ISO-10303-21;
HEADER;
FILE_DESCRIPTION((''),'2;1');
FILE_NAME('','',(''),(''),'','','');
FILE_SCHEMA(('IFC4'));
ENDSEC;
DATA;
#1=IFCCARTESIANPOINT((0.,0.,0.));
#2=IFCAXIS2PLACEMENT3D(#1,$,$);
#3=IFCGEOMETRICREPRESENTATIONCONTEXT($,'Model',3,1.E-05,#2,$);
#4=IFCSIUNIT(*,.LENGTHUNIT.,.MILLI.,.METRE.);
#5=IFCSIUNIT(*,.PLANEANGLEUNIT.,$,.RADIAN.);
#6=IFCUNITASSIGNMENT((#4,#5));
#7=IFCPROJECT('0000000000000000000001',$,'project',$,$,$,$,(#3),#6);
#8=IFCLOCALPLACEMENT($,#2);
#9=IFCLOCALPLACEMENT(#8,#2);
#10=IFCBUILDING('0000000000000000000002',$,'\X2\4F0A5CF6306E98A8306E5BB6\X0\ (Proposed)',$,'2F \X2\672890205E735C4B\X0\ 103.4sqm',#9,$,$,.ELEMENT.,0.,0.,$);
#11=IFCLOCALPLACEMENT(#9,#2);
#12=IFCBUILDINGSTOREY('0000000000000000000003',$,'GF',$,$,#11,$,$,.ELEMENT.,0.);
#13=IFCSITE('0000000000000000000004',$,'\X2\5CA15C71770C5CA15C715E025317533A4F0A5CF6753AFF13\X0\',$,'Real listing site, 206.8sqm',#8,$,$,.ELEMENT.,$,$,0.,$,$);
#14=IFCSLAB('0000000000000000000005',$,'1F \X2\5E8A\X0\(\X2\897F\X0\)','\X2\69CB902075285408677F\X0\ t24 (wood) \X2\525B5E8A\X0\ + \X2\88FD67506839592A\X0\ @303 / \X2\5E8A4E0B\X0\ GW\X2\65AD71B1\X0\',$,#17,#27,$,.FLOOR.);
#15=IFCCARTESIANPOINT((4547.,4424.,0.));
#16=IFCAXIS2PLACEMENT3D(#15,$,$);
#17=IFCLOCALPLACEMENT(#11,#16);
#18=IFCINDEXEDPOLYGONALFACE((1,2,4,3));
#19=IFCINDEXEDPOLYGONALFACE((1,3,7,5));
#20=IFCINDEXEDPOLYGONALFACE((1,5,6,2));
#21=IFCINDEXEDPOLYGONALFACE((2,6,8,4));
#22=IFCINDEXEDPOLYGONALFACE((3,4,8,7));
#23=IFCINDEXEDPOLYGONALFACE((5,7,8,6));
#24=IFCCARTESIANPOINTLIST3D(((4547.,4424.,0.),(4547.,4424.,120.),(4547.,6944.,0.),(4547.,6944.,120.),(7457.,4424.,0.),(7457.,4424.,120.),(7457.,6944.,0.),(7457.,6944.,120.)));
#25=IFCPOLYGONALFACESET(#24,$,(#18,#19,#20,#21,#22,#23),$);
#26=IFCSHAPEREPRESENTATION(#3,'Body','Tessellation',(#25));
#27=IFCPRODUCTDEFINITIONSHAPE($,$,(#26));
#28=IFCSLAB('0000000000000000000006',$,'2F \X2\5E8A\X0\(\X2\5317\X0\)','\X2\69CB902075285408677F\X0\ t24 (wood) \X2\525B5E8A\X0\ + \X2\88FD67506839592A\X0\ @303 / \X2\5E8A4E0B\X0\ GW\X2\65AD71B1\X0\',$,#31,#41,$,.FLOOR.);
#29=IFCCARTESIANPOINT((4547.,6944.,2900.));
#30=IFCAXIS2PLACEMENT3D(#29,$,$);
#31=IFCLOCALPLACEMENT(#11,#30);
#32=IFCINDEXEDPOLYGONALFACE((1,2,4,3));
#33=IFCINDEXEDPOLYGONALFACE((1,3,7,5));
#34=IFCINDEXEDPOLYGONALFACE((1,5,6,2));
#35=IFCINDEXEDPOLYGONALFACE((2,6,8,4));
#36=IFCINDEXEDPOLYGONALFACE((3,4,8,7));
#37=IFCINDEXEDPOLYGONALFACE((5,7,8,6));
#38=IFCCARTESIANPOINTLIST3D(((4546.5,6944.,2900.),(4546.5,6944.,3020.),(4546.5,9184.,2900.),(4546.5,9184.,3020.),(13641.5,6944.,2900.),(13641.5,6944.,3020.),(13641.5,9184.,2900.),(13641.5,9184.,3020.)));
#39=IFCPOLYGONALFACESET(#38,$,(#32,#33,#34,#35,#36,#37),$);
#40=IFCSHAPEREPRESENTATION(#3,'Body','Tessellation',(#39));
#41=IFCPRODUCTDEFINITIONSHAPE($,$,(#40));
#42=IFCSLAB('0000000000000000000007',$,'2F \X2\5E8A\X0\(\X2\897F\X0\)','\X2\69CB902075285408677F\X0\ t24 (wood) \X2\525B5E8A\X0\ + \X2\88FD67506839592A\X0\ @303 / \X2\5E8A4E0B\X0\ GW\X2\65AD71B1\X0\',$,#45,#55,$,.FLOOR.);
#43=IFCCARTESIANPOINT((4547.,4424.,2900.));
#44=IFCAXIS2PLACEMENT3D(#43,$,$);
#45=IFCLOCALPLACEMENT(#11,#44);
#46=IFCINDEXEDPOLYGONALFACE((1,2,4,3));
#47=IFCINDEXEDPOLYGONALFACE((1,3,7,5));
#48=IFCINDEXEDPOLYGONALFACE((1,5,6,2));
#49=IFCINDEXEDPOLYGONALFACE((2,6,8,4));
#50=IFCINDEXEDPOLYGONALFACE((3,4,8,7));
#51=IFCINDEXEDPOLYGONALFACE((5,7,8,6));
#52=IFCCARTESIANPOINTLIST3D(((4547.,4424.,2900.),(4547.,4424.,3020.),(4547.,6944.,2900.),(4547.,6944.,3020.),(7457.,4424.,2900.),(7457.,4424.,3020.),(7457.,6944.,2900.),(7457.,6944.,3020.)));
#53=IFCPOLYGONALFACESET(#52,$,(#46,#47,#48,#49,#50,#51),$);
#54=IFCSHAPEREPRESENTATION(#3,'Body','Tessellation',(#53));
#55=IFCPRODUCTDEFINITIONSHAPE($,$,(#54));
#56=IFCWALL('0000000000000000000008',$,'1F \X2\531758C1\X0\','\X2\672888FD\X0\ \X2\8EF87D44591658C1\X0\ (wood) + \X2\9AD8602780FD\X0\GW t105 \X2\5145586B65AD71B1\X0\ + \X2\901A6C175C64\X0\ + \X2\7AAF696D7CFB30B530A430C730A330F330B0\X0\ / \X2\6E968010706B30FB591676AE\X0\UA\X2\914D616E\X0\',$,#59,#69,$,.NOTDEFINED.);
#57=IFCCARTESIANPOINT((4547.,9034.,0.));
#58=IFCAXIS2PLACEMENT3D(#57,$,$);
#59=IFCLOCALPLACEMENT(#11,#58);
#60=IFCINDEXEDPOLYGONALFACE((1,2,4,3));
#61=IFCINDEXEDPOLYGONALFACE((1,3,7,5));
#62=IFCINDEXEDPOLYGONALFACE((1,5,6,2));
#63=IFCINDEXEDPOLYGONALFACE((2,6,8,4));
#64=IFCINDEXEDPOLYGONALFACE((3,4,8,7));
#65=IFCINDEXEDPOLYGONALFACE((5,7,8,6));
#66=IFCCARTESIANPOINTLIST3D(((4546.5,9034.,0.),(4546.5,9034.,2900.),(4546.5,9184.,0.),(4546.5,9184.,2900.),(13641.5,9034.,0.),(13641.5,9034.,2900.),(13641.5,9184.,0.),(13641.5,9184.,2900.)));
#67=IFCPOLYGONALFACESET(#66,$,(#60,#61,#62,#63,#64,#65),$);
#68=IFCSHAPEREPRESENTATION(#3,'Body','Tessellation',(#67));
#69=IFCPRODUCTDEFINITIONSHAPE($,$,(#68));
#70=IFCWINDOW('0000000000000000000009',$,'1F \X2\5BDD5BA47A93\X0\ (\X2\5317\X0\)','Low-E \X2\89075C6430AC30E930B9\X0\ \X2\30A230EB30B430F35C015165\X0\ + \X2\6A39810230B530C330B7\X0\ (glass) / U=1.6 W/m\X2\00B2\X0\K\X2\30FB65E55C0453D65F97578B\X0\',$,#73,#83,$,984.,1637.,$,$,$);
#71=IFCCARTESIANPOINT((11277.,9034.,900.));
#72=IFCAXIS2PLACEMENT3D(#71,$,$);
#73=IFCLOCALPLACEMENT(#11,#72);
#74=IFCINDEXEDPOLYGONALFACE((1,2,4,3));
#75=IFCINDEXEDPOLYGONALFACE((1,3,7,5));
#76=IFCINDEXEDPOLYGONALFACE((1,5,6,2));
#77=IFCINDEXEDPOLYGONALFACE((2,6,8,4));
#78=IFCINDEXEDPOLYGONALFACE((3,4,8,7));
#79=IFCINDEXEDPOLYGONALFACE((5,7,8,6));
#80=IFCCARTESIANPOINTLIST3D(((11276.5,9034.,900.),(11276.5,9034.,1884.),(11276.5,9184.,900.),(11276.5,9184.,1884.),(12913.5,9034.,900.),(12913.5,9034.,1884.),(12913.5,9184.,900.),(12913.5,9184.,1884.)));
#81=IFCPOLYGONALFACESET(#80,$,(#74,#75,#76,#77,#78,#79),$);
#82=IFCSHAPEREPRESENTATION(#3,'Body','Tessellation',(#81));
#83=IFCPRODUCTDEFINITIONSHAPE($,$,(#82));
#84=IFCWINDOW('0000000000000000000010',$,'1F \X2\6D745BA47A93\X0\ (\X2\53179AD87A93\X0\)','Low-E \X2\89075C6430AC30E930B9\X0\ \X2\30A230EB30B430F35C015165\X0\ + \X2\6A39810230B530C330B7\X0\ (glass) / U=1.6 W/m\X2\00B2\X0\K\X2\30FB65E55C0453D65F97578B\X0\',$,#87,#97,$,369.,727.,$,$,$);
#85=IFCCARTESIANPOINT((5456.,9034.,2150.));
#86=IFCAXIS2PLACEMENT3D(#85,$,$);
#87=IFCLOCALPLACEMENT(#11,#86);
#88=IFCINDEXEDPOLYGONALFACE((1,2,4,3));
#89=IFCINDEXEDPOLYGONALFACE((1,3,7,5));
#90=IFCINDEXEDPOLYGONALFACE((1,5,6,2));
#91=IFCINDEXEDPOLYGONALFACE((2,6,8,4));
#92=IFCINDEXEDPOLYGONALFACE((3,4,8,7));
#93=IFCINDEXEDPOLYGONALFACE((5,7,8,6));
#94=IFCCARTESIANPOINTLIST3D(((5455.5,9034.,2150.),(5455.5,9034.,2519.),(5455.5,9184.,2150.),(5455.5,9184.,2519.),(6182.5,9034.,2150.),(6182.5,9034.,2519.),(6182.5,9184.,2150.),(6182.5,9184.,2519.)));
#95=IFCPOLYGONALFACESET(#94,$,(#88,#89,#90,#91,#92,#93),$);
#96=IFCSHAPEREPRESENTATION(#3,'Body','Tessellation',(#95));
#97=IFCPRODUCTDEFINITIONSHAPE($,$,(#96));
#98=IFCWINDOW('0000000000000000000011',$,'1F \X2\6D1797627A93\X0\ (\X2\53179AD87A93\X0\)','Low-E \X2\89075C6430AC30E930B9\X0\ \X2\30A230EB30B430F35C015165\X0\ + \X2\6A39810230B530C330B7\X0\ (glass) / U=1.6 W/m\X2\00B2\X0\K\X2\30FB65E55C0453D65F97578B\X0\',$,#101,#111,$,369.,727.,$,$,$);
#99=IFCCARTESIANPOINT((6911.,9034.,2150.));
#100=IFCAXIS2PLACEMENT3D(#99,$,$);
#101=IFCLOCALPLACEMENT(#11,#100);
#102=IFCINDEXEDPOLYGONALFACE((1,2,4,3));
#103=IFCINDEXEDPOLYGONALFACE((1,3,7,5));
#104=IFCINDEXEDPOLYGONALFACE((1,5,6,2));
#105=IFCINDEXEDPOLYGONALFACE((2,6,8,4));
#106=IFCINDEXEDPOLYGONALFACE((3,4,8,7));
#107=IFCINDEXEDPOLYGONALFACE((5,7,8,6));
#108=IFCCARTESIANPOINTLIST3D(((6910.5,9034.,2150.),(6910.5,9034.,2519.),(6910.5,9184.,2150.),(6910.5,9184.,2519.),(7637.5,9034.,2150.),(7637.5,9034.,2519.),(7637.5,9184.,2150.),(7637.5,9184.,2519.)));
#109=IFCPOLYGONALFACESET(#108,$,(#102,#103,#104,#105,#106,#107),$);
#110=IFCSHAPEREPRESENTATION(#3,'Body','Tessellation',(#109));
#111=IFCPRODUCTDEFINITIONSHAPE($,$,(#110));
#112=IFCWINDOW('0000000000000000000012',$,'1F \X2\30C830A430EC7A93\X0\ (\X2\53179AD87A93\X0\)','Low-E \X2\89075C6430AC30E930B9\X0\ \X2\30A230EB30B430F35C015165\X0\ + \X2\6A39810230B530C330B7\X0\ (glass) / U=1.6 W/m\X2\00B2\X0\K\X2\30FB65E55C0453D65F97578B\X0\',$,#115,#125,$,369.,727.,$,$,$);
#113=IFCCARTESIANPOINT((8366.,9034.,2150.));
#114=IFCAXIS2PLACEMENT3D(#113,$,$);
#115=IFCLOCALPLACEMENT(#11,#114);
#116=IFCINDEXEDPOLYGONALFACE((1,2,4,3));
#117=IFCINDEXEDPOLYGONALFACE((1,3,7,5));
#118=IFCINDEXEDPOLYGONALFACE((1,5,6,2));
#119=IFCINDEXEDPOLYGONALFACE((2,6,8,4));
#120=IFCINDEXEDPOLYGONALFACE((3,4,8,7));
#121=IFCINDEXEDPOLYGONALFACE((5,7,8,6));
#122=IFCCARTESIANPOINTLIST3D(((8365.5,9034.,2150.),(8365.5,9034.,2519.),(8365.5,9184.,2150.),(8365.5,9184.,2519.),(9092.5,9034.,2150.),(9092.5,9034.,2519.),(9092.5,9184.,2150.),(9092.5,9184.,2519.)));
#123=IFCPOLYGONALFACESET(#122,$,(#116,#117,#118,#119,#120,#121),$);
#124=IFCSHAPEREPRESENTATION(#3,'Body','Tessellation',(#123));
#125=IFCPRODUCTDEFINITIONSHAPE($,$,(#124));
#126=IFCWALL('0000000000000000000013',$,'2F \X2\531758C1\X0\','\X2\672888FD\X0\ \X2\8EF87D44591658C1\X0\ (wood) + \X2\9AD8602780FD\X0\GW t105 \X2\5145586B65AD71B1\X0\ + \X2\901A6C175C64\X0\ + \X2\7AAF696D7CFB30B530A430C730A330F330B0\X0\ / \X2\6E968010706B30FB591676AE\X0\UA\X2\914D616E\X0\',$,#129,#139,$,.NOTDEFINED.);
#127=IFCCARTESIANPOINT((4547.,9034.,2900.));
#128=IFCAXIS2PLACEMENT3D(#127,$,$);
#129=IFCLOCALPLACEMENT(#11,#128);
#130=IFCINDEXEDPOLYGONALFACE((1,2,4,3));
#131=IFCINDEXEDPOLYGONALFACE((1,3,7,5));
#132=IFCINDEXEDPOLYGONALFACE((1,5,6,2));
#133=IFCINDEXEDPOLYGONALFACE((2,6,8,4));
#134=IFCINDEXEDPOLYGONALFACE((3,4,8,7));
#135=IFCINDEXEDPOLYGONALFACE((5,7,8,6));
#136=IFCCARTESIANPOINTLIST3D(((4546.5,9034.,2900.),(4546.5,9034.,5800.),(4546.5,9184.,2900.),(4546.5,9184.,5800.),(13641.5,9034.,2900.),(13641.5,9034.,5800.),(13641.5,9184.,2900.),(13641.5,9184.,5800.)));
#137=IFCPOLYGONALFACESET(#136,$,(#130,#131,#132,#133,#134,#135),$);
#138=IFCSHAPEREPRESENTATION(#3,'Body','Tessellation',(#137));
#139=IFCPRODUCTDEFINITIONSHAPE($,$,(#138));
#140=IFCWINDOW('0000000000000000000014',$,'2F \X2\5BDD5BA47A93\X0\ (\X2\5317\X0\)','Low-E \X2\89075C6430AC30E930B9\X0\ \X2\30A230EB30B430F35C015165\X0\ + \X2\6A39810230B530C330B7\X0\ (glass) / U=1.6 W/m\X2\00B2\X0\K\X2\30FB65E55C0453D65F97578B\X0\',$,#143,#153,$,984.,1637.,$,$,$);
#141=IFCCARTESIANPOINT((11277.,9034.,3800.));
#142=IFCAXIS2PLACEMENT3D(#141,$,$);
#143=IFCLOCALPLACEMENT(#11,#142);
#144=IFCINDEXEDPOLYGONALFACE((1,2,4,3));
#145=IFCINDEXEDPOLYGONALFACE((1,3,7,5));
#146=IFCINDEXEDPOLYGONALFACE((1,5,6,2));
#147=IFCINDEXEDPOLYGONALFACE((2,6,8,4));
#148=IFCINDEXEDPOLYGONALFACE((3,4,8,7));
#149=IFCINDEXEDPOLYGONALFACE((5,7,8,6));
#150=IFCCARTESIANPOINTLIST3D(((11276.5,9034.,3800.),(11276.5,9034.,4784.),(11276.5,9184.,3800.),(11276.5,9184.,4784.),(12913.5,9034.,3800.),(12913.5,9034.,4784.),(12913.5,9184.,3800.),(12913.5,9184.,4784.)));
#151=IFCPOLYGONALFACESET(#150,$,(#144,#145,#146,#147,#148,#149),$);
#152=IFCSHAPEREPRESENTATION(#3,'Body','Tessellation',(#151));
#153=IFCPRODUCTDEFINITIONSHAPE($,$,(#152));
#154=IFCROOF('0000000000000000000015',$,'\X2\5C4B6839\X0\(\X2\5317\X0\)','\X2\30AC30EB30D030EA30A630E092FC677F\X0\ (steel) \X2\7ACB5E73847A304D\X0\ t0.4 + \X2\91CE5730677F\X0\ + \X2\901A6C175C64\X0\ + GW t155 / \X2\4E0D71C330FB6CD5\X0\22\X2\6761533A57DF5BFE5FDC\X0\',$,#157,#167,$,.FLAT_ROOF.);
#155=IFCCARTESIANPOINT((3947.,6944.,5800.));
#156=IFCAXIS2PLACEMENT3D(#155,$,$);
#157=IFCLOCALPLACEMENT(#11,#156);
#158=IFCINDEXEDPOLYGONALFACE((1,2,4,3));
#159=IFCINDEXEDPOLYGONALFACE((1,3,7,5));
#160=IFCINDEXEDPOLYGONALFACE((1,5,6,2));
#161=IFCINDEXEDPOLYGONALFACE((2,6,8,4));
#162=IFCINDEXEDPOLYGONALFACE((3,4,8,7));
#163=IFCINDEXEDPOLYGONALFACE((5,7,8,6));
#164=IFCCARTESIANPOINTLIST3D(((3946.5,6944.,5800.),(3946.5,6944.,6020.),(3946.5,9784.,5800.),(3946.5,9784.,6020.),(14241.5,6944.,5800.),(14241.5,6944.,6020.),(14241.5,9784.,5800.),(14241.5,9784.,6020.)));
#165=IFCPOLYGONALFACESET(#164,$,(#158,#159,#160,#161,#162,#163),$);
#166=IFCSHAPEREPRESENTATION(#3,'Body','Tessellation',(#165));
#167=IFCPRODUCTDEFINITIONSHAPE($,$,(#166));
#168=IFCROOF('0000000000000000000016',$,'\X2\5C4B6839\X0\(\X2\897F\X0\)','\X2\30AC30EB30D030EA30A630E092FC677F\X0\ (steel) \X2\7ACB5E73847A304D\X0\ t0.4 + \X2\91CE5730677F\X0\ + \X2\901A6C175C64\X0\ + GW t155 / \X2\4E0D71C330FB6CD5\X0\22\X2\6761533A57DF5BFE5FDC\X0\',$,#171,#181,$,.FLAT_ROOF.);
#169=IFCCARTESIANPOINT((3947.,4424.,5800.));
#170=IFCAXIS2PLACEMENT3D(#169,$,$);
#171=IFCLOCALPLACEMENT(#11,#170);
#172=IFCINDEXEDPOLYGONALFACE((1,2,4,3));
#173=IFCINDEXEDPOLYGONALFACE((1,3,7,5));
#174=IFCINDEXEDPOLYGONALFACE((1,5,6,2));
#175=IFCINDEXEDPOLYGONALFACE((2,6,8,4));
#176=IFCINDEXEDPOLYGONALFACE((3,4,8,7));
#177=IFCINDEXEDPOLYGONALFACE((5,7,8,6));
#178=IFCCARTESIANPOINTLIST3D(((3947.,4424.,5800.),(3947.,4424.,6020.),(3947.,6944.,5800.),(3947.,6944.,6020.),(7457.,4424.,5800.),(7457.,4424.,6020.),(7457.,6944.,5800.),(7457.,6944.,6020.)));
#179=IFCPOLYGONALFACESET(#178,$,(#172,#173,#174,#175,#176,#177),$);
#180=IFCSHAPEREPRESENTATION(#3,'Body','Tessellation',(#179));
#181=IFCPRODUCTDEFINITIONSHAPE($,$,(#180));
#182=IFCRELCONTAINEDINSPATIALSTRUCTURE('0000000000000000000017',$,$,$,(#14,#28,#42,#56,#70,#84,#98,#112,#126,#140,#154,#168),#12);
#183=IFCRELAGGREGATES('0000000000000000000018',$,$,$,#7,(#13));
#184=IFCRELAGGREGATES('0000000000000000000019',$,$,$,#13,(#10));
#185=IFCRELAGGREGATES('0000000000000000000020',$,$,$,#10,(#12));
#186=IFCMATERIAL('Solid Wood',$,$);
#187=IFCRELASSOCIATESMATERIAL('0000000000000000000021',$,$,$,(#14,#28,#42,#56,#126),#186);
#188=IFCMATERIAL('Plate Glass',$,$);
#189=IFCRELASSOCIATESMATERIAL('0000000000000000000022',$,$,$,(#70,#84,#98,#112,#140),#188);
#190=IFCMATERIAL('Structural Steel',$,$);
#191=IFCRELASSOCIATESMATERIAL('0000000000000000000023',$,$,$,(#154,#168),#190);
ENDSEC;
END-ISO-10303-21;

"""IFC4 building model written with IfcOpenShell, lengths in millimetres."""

from ifc_helpers import new_model, si_unit, frame, frame_2d, origin, place, context, project, spatial, rectangle, extrude, material, element, fill, save


model = new_model("IFC4")

# Units and contexts
model_context = context("Model", 3, precision=1e-05, world=origin())
ifc_project = project(units=[si_unit("LENGTHUNIT", "METRE", prefix="MILLI"), si_unit("PLANEANGLEUNIT", "RADIAN")], contexts=[model_context])

# Site, building, storey
site_placement = place(None, origin())
site = spatial("IfcSite", under=ifc_project, at=site_placement, Name="岡山県岡山市北区伊島町３", ObjectType="Real listing site, 206.8sqm", CompositionType="ELEMENT", RefElevation=0.0)
building_placement = place(site_placement, origin())
building = spatial("IfcBuilding", under=site, at=building_placement, Name="伊島の風の家 (Proposed)", ObjectType="2F 木造平屋 103.4sqm", CompositionType="ELEMENT", ElevationOfRefHeight=0.0, ElevationOfTerrain=0.0)
storey_placement = place(building_placement, origin())
storey = spatial("IfcBuildingStorey", under=building, at=storey_placement, Name="GF", CompositionType="ELEMENT", Elevation=0.0)

# Slabs
ifc_material_1 = material(Name="Solid Wood")
slab_1_placement = place(storey_placement, frame((4547.0, 4424.0, 0.0)))
element("IfcSlab", 1, at=slab_1_placement, inside=storey, material=ifc_material_1, Name="1F 床(西)", Description="構造用合板 t24 (wood) 剛床 + 製材根太 @303 / 床下 GW断熱", PredefinedType="FLOOR", context=model_context, shape_type="SweptSolid", body=[
    extrude(rectangle(XDim=2910.0, YDim=2520.0, at=frame_2d((1455.0, 1260.0))), frame((4547.0, 4424.0, 0.0)), (0.0, 0.0, 1.0), 120.0),
])
slab_2_placement = place(storey_placement, frame((4547.0, 6944.0, 2900.0)))
element("IfcSlab", 2, at=slab_2_placement, inside=storey, material=ifc_material_1, Name="2F 床(北)", Description="構造用合板 t24 (wood) 剛床 + 製材根太 @303 / 床下 GW断熱", PredefinedType="FLOOR", context=model_context, shape_type="SweptSolid", body=[
    extrude(rectangle(XDim=9095.0, YDim=2240.0, at=frame_2d((4547.0, 1120.0))), frame((4547.0, 6944.0, 2900.0)), (0.0, 0.0, 1.0), 120.0),
])
slab_3_placement = place(storey_placement, frame((4547.0, 4424.0, 2900.0)))
element("IfcSlab", 3, at=slab_3_placement, inside=storey, material=ifc_material_1, Name="2F 床(西)", Description="構造用合板 t24 (wood) 剛床 + 製材根太 @303 / 床下 GW断熱", PredefinedType="FLOOR", context=model_context, shape_type="SweptSolid", body=[
    extrude(rectangle(XDim=2910.0, YDim=2520.0, at=frame_2d((1455.0, 1260.0))), frame((4547.0, 4424.0, 2900.0)), (0.0, 0.0, 1.0), 120.0),
])

# Wall, openings, windows
wall_1_placement = place(storey_placement, frame((4547.0, 9034.0, 0.0)))
wall_1 = element("IfcWall", 4, at=wall_1_placement, inside=storey, material=ifc_material_1, Name="1F 北壁", Description="木製 軸組外壁 (wood) + 高性能GW t105 充填断熱 + 通気層 + 窯業系サイディング / 準耐火・外皮UA配慮", PredefinedType="NOTDEFINED", context=model_context, shape_type="SweptSolid", body=[
    extrude(rectangle(XDim=9095.0, YDim=150.0, at=frame_2d((4547.0, 75.0))), frame((4547.0, 9034.0, 0.0)), (0.0, 0.0, 1.0), 2900.0),
])
opening_1_placement = place(storey_placement, frame((11277.0, 9034.0, 900.0)))
opening_1 = element("IfcOpeningElement", 5, at=opening_1_placement, cuts=wall_1, PredefinedType="NOTDEFINED", context=model_context, shape_type="SweptSolid", body=[
    extrude(rectangle(XDim=1637.0, YDim=150.0, at=frame_2d((818.0, 75.0))), frame((11277.0, 9034.0, 900.0)), (0.0, 0.0, 1.0), 984.0),
])
opening_2_placement = place(storey_placement, frame((5456.0, 9034.0, 2150.0)))
opening_2 = element("IfcOpeningElement", 6, at=opening_2_placement, cuts=wall_1, PredefinedType="NOTDEFINED", context=model_context, shape_type="SweptSolid", body=[
    extrude(rectangle(XDim=727.0, YDim=150.0, at=frame_2d((363.0, 75.0))), frame((5456.0, 9034.0, 2150.0)), (0.0, 0.0, 1.0), 369.0),
])
opening_3_placement = place(storey_placement, frame((6911.0, 9034.0, 2150.0)))
opening_3 = element("IfcOpeningElement", 7, at=opening_3_placement, cuts=wall_1, PredefinedType="NOTDEFINED", context=model_context, shape_type="SweptSolid", body=[
    extrude(rectangle(XDim=727.0, YDim=150.0, at=frame_2d((363.0, 75.0))), frame((6911.0, 9034.0, 2150.0)), (0.0, 0.0, 1.0), 369.0),
])
opening_4_placement = place(storey_placement, frame((8366.0, 9034.0, 2150.0)))
opening_4 = element("IfcOpeningElement", 8, at=opening_4_placement, cuts=wall_1, PredefinedType="NOTDEFINED", context=model_context, shape_type="SweptSolid", body=[
    extrude(rectangle(XDim=727.0, YDim=150.0, at=frame_2d((363.0, 75.0))), frame((8366.0, 9034.0, 2150.0)), (0.0, 0.0, 1.0), 369.0),
])
ifc_material_2 = material(Name="Plate Glass")
window_1_placement = place(storey_placement, frame((11277.0, 9034.0, 900.0)))
window_1 = element("IfcWindow", 9, at=window_1_placement, inside=storey, material=ifc_material_2, Name="1F 寝室窓 (北)", Description="Low-E 複層ガラス アルゴン封入 + 樹脂サッシ (glass) / U=1.6 W/m²K・日射取得型", OverallHeight=984.0, OverallWidth=1637.0, context=model_context, shape_type="SweptSolid", body=[
    extrude(rectangle(XDim=1637.0, YDim=150.0, at=frame_2d((818.0, 75.0))), frame((11277.0, 9034.0, 900.0)), (0.0, 0.0, 1.0), 984.0),
])
fill(opening_1, window_1)
window_2_placement = place(storey_placement, frame((5456.0, 9034.0, 2150.0)))
window_2 = element("IfcWindow", 10, at=window_2_placement, inside=storey, material=ifc_material_2, Name="1F 浴室窓 (北高窓)", Description="Low-E 複層ガラス アルゴン封入 + 樹脂サッシ (glass) / U=1.6 W/m²K・日射取得型", OverallHeight=369.0, OverallWidth=727.0, context=model_context, shape_type="SweptSolid", body=[
    extrude(rectangle(XDim=727.0, YDim=150.0, at=frame_2d((363.0, 75.0))), frame((5456.0, 9034.0, 2150.0)), (0.0, 0.0, 1.0), 369.0),
])
fill(opening_2, window_2)
window_3_placement = place(storey_placement, frame((6911.0, 9034.0, 2150.0)))
window_3 = element("IfcWindow", 11, at=window_3_placement, inside=storey, material=ifc_material_2, Name="1F 洗面窓 (北高窓)", Description="Low-E 複層ガラス アルゴン封入 + 樹脂サッシ (glass) / U=1.6 W/m²K・日射取得型", OverallHeight=369.0, OverallWidth=727.0, context=model_context, shape_type="SweptSolid", body=[
    extrude(rectangle(XDim=727.0, YDim=150.0, at=frame_2d((363.0, 75.0))), frame((6911.0, 9034.0, 2150.0)), (0.0, 0.0, 1.0), 369.0),
])
fill(opening_3, window_3)
window_4_placement = place(storey_placement, frame((8366.0, 9034.0, 2150.0)))
window_4 = element("IfcWindow", 12, at=window_4_placement, inside=storey, material=ifc_material_2, Name="1F トイレ窓 (北高窓)", Description="Low-E 複層ガラス アルゴン封入 + 樹脂サッシ (glass) / U=1.6 W/m²K・日射取得型", OverallHeight=369.0, OverallWidth=727.0, context=model_context, shape_type="SweptSolid", body=[
    extrude(rectangle(XDim=727.0, YDim=150.0, at=frame_2d((363.0, 75.0))), frame((8366.0, 9034.0, 2150.0)), (0.0, 0.0, 1.0), 369.0),
])
fill(opening_4, window_4)

# Wall, opening, window
wall_2_placement = place(storey_placement, frame((4547.0, 9034.0, 2900.0)))
wall_2 = element("IfcWall", 13, at=wall_2_placement, inside=storey, material=ifc_material_1, Name="2F 北壁", Description="木製 軸組外壁 (wood) + 高性能GW t105 充填断熱 + 通気層 + 窯業系サイディング / 準耐火・外皮UA配慮", PredefinedType="NOTDEFINED", context=model_context, shape_type="SweptSolid", body=[
    extrude(rectangle(XDim=9095.0, YDim=150.0, at=frame_2d((4547.0, 75.0))), frame((4547.0, 9034.0, 2900.0)), (0.0, 0.0, 1.0), 2900.0),
])
opening_5_placement = place(storey_placement, frame((11277.0, 9034.0, 3800.0)))
opening_5 = element("IfcOpeningElement", 14, at=opening_5_placement, cuts=wall_2, PredefinedType="NOTDEFINED", context=model_context, shape_type="SweptSolid", body=[
    extrude(rectangle(XDim=1637.0, YDim=150.0, at=frame_2d((818.0, 75.0))), frame((11277.0, 9034.0, 3800.0)), (0.0, 0.0, 1.0), 984.0),
])
window_5_placement = place(storey_placement, frame((11277.0, 9034.0, 3800.0)))
window_5 = element("IfcWindow", 15, at=window_5_placement, inside=storey, material=ifc_material_2, Name="2F 寝室窓 (北)", Description="Low-E 複層ガラス アルゴン封入 + 樹脂サッシ (glass) / U=1.6 W/m²K・日射取得型", OverallHeight=984.0, OverallWidth=1637.0, context=model_context, shape_type="SweptSolid", body=[
    extrude(rectangle(XDim=1637.0, YDim=150.0, at=frame_2d((818.0, 75.0))), frame((11277.0, 9034.0, 3800.0)), (0.0, 0.0, 1.0), 984.0),
])
fill(opening_5, window_5)

# Roofs
ifc_material_3 = material(Name="Structural Steel")
for number, where, name in (
    (16, (3947.0, 6944.0, 5800.0), "屋根(北)"),
):
    element("IfcRoof", number, at=place(storey_placement, frame(where)), inside=storey, material=ifc_material_3, Name=name, Description="ガルバリウム鋼板 (steel) 立平葺き t0.4 + 野地板 + 通気層 + GW t155 / 不燃・法22条区域対応", PredefinedType="FLAT_ROOF", context=model_context, shape_type="SweptSolid", body=[
        extrude(rectangle(XDim=10295.0, YDim=2840.0, at=frame_2d((5147.0, 1420.0))), frame((3947.0, 6944.0, 5800.0)), (0.0, 0.0, 1.0), 220.0),
    ])
roof_placement = place(storey_placement, frame((3947.0, 4424.0, 5800.0)))
element("IfcRoof", 17, at=roof_placement, inside=storey, material=ifc_material_3, Name="屋根(西)", Description="ガルバリウム鋼板 (steel) 立平葺き t0.4 + 野地板 + 通気層 + GW t155 / 不燃・法22条区域対応", PredefinedType="FLAT_ROOF", context=model_context, shape_type="SweptSolid", body=[
    extrude(rectangle(XDim=3510.0, YDim=2520.0, at=frame_2d((1755.0, 1260.0))), frame((3947.0, 4424.0, 5800.0)), (0.0, 0.0, 1.0), 220.0),
])

save(model, "model.ifc")
